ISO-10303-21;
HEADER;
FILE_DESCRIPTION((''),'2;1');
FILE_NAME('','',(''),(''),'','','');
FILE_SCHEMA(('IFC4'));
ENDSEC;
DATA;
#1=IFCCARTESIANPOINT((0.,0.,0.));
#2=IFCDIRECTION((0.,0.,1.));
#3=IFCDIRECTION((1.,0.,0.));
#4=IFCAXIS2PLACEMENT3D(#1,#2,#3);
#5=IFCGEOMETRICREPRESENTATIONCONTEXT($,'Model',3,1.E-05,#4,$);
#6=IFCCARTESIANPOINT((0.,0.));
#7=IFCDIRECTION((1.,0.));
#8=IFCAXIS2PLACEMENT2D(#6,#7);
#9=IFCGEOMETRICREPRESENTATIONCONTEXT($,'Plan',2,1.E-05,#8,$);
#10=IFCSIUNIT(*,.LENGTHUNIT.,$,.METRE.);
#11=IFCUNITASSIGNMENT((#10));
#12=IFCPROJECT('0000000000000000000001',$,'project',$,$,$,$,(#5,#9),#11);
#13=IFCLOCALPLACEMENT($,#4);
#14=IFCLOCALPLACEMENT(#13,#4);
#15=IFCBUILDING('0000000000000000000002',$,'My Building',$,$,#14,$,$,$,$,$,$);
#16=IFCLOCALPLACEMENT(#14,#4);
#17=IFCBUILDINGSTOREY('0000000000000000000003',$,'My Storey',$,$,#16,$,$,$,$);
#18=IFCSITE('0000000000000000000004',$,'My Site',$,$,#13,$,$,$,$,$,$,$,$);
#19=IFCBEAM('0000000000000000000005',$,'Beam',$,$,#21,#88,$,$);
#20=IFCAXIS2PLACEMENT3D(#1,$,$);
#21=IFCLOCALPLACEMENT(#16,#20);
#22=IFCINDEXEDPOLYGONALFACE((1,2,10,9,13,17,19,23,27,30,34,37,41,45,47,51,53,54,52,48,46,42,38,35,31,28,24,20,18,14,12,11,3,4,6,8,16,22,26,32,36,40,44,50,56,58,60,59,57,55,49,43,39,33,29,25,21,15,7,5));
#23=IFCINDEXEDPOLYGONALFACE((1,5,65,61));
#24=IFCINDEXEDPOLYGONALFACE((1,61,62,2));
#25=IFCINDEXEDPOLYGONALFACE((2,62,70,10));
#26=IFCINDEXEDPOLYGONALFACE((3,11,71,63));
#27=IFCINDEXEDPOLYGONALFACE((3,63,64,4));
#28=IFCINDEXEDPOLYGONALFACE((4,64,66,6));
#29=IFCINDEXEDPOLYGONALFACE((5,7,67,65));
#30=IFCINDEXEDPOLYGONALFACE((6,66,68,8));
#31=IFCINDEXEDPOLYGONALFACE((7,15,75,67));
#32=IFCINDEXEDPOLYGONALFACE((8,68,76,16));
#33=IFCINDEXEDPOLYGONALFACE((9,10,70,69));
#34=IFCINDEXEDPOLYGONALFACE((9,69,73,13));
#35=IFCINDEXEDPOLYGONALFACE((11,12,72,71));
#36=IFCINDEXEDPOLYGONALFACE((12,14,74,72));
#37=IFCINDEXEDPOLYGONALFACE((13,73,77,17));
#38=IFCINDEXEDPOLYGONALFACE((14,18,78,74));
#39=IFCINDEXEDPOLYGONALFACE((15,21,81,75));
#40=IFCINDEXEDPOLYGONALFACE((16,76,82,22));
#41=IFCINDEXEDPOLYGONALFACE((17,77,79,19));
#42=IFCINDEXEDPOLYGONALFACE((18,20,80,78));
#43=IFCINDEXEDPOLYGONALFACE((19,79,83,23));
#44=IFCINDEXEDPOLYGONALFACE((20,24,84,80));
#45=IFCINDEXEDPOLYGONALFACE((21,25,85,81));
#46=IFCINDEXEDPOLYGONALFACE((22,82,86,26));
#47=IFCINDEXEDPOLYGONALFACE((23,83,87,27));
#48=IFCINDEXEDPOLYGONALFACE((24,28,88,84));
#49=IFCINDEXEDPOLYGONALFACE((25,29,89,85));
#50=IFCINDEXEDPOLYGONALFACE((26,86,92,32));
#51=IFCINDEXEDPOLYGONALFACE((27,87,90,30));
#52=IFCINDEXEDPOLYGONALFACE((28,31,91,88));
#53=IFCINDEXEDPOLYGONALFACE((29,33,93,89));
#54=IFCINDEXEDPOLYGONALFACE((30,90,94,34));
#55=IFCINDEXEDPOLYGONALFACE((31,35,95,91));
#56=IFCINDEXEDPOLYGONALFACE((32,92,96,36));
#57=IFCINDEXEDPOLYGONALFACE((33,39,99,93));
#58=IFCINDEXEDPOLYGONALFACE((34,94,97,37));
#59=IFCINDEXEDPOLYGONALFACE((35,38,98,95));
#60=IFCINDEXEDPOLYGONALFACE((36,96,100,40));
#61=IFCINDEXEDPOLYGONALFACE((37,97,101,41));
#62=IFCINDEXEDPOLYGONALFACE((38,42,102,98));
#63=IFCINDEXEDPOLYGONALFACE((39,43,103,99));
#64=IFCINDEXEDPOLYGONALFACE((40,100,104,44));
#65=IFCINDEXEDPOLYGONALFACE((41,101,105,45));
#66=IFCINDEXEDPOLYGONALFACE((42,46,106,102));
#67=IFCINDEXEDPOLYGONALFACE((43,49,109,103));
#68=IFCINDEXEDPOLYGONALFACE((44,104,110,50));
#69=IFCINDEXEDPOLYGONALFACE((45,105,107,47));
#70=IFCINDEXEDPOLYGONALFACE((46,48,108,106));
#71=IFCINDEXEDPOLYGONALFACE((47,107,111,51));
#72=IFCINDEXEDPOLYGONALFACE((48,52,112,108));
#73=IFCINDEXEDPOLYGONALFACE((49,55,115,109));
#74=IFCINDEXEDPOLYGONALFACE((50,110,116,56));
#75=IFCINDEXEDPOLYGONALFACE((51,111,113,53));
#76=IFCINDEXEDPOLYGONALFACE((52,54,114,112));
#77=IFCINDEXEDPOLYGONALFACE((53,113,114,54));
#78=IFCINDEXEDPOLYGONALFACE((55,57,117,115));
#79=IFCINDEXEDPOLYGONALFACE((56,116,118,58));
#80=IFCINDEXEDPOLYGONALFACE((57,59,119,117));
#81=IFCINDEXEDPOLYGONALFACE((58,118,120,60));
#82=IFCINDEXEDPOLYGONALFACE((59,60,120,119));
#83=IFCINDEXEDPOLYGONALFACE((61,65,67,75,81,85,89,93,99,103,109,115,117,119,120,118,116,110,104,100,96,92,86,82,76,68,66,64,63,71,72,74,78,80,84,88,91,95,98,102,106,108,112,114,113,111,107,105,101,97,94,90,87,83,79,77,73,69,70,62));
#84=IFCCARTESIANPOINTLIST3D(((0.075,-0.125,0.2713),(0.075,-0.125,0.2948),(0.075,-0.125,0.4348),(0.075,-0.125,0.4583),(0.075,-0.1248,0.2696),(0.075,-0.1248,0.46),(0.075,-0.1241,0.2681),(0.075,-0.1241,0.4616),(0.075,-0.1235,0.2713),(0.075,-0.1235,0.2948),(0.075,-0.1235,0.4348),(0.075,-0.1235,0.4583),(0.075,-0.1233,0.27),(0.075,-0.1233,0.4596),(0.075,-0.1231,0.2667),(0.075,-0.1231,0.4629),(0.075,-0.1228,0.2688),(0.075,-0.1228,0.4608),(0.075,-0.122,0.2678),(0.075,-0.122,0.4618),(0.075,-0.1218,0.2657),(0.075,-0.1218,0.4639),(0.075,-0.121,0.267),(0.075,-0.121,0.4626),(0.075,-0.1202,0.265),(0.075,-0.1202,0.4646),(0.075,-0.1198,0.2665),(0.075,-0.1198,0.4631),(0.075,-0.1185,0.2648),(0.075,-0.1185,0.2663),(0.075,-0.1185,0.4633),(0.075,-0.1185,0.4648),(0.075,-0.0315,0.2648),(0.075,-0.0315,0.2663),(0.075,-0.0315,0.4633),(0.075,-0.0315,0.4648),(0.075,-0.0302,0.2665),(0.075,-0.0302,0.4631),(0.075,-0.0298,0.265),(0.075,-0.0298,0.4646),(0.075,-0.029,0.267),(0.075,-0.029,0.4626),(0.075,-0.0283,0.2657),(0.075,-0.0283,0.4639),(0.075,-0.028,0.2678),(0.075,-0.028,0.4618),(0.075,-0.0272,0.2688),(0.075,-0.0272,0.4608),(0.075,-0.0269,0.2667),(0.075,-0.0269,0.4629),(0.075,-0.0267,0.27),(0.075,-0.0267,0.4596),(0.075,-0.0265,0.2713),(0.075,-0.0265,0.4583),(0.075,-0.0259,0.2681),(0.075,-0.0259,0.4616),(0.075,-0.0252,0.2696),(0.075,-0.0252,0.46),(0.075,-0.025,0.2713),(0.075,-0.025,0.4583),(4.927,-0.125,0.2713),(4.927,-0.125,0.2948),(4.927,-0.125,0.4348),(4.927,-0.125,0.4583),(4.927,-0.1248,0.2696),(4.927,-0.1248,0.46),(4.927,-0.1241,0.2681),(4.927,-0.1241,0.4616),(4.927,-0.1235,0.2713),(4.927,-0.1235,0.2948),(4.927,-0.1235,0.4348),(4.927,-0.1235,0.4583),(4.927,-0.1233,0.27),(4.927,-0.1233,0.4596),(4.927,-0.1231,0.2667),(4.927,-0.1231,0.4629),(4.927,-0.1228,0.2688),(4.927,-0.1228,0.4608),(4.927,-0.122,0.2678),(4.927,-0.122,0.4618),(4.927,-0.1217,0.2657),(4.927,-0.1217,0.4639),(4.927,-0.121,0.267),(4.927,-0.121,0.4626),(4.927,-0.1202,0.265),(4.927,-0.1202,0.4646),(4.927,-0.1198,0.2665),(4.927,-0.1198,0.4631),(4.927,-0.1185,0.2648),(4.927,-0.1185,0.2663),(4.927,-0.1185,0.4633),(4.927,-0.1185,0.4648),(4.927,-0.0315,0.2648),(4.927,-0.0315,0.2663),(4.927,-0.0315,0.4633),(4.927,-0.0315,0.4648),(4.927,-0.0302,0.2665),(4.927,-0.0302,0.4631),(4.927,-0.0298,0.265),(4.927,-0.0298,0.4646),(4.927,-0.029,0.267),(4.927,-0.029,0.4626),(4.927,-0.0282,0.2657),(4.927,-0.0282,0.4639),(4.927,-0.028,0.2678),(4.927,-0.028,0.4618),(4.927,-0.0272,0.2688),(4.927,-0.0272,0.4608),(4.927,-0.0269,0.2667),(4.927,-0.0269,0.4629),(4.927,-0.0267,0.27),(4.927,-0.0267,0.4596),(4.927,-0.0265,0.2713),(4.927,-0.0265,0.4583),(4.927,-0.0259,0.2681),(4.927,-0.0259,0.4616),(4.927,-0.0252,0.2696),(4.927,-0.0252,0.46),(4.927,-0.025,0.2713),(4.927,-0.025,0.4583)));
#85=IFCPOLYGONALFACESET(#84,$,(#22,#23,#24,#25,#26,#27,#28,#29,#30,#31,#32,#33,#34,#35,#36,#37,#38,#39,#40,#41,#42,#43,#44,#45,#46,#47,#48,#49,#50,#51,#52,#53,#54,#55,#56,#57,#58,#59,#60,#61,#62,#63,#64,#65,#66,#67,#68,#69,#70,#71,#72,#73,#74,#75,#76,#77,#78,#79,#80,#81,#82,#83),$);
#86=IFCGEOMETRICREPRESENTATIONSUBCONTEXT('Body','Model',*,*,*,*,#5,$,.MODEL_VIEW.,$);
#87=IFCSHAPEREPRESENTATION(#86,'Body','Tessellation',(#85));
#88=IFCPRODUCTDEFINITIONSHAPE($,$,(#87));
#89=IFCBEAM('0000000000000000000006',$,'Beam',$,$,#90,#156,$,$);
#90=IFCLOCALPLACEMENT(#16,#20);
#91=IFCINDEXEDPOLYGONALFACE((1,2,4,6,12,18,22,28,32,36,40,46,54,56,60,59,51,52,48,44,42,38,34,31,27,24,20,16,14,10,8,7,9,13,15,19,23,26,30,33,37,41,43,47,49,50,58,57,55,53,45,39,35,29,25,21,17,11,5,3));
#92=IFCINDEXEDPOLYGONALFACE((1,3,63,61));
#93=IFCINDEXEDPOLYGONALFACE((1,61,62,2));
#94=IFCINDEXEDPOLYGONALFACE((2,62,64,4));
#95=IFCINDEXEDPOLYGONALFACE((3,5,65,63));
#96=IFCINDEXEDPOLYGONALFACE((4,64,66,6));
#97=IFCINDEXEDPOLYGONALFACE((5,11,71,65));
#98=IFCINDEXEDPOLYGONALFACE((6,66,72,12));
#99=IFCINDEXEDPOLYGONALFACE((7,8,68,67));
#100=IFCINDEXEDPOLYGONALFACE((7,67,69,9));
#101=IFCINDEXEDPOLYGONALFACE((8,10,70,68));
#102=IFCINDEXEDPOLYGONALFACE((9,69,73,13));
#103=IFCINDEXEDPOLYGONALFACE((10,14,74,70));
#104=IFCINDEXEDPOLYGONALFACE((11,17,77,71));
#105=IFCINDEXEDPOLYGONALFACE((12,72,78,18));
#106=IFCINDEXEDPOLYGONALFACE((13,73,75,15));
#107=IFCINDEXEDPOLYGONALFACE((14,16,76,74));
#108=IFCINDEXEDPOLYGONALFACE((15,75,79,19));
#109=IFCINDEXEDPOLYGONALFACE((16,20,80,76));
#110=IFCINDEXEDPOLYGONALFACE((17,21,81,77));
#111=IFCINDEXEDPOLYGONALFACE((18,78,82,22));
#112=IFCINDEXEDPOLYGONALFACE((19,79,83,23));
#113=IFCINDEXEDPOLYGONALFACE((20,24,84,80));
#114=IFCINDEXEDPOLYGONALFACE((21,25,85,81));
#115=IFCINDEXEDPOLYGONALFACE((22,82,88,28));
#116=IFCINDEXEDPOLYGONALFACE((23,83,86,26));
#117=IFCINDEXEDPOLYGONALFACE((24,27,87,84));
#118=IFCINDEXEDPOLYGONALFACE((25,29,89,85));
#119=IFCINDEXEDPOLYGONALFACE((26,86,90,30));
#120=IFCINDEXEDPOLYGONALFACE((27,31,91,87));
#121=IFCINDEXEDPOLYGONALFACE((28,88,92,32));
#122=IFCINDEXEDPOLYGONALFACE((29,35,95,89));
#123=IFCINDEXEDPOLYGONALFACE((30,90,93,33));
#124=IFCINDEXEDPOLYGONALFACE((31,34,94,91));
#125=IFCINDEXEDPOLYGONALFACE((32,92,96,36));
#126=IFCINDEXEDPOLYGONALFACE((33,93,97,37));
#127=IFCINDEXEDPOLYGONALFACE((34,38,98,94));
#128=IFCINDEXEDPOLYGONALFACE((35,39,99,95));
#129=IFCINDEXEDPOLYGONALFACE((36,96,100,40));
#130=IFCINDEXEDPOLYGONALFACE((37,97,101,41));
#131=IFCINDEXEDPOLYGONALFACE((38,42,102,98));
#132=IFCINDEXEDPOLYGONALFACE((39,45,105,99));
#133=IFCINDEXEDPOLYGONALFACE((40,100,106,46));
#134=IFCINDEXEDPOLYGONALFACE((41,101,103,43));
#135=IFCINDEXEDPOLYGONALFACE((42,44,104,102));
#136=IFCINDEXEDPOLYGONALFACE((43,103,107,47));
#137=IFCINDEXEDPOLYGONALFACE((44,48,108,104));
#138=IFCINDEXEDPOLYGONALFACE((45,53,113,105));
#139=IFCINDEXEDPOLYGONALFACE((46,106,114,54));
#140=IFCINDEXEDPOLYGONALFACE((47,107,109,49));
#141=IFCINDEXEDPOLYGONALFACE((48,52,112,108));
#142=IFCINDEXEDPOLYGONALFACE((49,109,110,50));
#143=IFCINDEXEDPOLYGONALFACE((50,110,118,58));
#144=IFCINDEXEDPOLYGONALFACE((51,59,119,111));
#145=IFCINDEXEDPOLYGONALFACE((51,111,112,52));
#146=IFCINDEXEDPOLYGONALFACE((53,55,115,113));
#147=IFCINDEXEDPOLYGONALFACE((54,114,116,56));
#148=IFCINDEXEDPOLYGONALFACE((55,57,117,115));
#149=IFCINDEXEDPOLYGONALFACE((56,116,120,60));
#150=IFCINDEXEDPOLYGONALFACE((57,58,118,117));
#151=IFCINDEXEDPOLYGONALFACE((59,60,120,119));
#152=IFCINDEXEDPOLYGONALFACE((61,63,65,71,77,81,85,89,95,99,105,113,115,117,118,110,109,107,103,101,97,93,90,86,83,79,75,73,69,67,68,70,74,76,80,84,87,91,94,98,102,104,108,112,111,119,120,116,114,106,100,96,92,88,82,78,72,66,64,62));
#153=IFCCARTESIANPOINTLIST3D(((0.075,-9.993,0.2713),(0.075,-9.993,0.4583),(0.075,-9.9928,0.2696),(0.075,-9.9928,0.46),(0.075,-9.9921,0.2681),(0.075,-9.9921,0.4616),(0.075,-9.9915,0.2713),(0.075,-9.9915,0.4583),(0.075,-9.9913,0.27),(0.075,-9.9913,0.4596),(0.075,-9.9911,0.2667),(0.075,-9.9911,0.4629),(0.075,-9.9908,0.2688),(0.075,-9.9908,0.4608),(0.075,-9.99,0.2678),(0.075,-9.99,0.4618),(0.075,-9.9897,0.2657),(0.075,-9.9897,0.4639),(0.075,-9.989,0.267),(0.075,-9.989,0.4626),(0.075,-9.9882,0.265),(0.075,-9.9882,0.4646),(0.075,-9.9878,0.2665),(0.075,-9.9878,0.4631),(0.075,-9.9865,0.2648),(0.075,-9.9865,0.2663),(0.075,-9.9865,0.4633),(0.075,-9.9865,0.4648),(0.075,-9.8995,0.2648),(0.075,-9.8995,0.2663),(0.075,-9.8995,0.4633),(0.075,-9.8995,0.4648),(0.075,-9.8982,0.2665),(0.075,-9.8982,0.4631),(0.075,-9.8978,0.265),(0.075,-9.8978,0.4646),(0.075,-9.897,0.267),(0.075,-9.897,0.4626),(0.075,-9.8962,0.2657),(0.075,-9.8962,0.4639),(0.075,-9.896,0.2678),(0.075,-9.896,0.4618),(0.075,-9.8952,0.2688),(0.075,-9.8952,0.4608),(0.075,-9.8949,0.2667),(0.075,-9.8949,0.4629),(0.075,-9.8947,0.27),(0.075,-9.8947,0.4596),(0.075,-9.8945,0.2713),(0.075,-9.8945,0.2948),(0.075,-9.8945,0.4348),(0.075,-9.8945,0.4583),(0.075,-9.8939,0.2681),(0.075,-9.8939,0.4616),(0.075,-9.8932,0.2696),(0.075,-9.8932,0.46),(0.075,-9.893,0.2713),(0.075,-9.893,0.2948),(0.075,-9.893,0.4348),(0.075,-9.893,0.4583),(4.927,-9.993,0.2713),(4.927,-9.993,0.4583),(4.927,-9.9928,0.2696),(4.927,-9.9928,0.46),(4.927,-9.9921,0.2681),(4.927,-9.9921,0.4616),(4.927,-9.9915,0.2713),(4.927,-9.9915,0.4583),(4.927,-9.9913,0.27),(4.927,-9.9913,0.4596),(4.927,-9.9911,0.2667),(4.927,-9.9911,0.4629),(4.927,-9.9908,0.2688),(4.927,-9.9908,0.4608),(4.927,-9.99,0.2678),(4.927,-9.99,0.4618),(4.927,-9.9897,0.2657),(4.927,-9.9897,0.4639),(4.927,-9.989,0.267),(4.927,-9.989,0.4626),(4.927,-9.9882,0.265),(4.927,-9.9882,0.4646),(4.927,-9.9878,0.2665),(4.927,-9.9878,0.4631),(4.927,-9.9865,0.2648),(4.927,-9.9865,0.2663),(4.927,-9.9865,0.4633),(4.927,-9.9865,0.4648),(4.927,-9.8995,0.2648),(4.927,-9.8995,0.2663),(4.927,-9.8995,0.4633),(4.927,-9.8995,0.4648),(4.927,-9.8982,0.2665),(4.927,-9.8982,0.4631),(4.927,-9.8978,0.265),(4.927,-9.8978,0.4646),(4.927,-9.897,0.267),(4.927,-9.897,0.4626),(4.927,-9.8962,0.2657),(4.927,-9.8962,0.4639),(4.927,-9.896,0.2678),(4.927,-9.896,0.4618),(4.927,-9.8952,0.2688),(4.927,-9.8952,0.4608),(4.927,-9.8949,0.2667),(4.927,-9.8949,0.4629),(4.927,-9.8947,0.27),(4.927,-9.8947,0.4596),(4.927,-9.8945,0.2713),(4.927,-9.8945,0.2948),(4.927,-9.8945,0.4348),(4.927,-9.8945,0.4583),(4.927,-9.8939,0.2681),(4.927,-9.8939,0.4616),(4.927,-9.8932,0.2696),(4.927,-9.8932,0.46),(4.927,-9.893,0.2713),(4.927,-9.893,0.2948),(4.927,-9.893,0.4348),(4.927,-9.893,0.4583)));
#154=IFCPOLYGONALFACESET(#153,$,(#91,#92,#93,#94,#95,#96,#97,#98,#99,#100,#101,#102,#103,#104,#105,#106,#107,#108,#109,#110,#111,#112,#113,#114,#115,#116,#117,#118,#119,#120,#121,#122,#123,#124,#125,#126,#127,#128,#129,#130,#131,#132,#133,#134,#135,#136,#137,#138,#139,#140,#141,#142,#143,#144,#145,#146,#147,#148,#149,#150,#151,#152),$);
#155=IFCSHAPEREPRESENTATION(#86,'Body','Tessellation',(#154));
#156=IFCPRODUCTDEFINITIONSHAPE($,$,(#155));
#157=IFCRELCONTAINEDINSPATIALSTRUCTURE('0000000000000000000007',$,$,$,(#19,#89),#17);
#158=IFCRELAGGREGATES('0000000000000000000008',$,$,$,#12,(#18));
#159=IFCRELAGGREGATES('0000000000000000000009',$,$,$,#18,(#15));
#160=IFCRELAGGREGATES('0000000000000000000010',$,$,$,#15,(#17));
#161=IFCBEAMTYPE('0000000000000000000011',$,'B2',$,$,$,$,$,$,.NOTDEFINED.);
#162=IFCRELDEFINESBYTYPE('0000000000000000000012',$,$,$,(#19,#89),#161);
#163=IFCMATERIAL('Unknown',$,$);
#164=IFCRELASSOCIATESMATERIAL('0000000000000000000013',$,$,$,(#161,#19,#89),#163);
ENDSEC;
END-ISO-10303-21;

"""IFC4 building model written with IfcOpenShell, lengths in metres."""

from ifc_helpers import new_model, si_unit, frame, origin_with_axes, origin_2d_with_axis, place, context, subcontext, project, spatial, c_section, extrude, material, material_profile, profile_set, profile_usage, type_object, element, save


model = new_model("IFC4")

# Units and contexts
model_context = context("Model", 3, precision=1e-05, world=origin_with_axes())
plan_context = context("Plan", 2, precision=1e-05, world=origin_2d_with_axis())
body_context = subcontext(model_context, "Body", "Model", "MODEL_VIEW")
ifc_project = project(units=[si_unit("LENGTHUNIT", "METRE")], contexts=[model_context, plan_context])

# Site, building, storey
site_placement = place(None, origin_with_axes())
site = spatial("IfcSite", under=ifc_project, at=site_placement, Name="My Site")
building_placement = place(site_placement, origin_with_axes())
building = spatial("IfcBuilding", under=site, at=building_placement, Name="My Building")
storey_placement = place(building_placement, origin_with_axes())
storey = spatial("IfcBuildingStorey", under=building, at=storey_placement, Name="My Storey")

# Shared definitions
ifc_material = material(Name="Unknown")

# Beams
ifc_material_profile_1 = material_profile(ifc_material, c_section(Depth=0.2, Width=0.1, WallThickness=0.0015, Girth=0.03, InternalFilletRadius=0.005))
ifc_profile_set_1 = profile_set([ifc_material_profile_1])
ifc_profile_usage_1 = profile_usage(ifc_profile_set_1, cardinal=5)
beam_type = type_object("IfcBeamType", Name="B2", PredefinedType="NOTDEFINED", material=ifc_profile_set_1)
beam_1_placement = place(storey_placement, frame((4.927, -0.075, 0.3648), z_axis=(-1.0, 0.0, 0.0), x_axis=(0.0, -1.0, 0.0)))
element("IfcBeam", 1, at=beam_1_placement, inside=storey, type_object=beam_type, material=ifc_profile_usage_1, Name="Beam", context=body_context, shape_type="SweptSolid", body=[
    extrude(c_section(Depth=0.2, Width=0.1, WallThickness=0.0015, Girth=0.03, InternalFilletRadius=0.005), origin_with_axes(), (0.0, 0.0, 1.0), 4.852),
])
ifc_profile_usage_2 = profile_usage(ifc_profile_set_1, cardinal=5)
beam_2_placement = place(storey_placement, frame((4.927, -9.943, 0.3648), z_axis=(-1.0, 0.0, 0.0), x_axis=(0.0, 1.0, 0.0)))
element("IfcBeam", 2, at=beam_2_placement, inside=storey, type_object=beam_type, material=ifc_profile_usage_2, Name="Beam", context=body_context, shape_type="SweptSolid", body=[
    extrude(c_section(Depth=0.2, Width=0.1, WallThickness=0.0015, Girth=0.03, InternalFilletRadius=0.005), origin_with_axes(), (0.0, 0.0, 1.0), 4.852),
])

save(model, "model.ifc")
